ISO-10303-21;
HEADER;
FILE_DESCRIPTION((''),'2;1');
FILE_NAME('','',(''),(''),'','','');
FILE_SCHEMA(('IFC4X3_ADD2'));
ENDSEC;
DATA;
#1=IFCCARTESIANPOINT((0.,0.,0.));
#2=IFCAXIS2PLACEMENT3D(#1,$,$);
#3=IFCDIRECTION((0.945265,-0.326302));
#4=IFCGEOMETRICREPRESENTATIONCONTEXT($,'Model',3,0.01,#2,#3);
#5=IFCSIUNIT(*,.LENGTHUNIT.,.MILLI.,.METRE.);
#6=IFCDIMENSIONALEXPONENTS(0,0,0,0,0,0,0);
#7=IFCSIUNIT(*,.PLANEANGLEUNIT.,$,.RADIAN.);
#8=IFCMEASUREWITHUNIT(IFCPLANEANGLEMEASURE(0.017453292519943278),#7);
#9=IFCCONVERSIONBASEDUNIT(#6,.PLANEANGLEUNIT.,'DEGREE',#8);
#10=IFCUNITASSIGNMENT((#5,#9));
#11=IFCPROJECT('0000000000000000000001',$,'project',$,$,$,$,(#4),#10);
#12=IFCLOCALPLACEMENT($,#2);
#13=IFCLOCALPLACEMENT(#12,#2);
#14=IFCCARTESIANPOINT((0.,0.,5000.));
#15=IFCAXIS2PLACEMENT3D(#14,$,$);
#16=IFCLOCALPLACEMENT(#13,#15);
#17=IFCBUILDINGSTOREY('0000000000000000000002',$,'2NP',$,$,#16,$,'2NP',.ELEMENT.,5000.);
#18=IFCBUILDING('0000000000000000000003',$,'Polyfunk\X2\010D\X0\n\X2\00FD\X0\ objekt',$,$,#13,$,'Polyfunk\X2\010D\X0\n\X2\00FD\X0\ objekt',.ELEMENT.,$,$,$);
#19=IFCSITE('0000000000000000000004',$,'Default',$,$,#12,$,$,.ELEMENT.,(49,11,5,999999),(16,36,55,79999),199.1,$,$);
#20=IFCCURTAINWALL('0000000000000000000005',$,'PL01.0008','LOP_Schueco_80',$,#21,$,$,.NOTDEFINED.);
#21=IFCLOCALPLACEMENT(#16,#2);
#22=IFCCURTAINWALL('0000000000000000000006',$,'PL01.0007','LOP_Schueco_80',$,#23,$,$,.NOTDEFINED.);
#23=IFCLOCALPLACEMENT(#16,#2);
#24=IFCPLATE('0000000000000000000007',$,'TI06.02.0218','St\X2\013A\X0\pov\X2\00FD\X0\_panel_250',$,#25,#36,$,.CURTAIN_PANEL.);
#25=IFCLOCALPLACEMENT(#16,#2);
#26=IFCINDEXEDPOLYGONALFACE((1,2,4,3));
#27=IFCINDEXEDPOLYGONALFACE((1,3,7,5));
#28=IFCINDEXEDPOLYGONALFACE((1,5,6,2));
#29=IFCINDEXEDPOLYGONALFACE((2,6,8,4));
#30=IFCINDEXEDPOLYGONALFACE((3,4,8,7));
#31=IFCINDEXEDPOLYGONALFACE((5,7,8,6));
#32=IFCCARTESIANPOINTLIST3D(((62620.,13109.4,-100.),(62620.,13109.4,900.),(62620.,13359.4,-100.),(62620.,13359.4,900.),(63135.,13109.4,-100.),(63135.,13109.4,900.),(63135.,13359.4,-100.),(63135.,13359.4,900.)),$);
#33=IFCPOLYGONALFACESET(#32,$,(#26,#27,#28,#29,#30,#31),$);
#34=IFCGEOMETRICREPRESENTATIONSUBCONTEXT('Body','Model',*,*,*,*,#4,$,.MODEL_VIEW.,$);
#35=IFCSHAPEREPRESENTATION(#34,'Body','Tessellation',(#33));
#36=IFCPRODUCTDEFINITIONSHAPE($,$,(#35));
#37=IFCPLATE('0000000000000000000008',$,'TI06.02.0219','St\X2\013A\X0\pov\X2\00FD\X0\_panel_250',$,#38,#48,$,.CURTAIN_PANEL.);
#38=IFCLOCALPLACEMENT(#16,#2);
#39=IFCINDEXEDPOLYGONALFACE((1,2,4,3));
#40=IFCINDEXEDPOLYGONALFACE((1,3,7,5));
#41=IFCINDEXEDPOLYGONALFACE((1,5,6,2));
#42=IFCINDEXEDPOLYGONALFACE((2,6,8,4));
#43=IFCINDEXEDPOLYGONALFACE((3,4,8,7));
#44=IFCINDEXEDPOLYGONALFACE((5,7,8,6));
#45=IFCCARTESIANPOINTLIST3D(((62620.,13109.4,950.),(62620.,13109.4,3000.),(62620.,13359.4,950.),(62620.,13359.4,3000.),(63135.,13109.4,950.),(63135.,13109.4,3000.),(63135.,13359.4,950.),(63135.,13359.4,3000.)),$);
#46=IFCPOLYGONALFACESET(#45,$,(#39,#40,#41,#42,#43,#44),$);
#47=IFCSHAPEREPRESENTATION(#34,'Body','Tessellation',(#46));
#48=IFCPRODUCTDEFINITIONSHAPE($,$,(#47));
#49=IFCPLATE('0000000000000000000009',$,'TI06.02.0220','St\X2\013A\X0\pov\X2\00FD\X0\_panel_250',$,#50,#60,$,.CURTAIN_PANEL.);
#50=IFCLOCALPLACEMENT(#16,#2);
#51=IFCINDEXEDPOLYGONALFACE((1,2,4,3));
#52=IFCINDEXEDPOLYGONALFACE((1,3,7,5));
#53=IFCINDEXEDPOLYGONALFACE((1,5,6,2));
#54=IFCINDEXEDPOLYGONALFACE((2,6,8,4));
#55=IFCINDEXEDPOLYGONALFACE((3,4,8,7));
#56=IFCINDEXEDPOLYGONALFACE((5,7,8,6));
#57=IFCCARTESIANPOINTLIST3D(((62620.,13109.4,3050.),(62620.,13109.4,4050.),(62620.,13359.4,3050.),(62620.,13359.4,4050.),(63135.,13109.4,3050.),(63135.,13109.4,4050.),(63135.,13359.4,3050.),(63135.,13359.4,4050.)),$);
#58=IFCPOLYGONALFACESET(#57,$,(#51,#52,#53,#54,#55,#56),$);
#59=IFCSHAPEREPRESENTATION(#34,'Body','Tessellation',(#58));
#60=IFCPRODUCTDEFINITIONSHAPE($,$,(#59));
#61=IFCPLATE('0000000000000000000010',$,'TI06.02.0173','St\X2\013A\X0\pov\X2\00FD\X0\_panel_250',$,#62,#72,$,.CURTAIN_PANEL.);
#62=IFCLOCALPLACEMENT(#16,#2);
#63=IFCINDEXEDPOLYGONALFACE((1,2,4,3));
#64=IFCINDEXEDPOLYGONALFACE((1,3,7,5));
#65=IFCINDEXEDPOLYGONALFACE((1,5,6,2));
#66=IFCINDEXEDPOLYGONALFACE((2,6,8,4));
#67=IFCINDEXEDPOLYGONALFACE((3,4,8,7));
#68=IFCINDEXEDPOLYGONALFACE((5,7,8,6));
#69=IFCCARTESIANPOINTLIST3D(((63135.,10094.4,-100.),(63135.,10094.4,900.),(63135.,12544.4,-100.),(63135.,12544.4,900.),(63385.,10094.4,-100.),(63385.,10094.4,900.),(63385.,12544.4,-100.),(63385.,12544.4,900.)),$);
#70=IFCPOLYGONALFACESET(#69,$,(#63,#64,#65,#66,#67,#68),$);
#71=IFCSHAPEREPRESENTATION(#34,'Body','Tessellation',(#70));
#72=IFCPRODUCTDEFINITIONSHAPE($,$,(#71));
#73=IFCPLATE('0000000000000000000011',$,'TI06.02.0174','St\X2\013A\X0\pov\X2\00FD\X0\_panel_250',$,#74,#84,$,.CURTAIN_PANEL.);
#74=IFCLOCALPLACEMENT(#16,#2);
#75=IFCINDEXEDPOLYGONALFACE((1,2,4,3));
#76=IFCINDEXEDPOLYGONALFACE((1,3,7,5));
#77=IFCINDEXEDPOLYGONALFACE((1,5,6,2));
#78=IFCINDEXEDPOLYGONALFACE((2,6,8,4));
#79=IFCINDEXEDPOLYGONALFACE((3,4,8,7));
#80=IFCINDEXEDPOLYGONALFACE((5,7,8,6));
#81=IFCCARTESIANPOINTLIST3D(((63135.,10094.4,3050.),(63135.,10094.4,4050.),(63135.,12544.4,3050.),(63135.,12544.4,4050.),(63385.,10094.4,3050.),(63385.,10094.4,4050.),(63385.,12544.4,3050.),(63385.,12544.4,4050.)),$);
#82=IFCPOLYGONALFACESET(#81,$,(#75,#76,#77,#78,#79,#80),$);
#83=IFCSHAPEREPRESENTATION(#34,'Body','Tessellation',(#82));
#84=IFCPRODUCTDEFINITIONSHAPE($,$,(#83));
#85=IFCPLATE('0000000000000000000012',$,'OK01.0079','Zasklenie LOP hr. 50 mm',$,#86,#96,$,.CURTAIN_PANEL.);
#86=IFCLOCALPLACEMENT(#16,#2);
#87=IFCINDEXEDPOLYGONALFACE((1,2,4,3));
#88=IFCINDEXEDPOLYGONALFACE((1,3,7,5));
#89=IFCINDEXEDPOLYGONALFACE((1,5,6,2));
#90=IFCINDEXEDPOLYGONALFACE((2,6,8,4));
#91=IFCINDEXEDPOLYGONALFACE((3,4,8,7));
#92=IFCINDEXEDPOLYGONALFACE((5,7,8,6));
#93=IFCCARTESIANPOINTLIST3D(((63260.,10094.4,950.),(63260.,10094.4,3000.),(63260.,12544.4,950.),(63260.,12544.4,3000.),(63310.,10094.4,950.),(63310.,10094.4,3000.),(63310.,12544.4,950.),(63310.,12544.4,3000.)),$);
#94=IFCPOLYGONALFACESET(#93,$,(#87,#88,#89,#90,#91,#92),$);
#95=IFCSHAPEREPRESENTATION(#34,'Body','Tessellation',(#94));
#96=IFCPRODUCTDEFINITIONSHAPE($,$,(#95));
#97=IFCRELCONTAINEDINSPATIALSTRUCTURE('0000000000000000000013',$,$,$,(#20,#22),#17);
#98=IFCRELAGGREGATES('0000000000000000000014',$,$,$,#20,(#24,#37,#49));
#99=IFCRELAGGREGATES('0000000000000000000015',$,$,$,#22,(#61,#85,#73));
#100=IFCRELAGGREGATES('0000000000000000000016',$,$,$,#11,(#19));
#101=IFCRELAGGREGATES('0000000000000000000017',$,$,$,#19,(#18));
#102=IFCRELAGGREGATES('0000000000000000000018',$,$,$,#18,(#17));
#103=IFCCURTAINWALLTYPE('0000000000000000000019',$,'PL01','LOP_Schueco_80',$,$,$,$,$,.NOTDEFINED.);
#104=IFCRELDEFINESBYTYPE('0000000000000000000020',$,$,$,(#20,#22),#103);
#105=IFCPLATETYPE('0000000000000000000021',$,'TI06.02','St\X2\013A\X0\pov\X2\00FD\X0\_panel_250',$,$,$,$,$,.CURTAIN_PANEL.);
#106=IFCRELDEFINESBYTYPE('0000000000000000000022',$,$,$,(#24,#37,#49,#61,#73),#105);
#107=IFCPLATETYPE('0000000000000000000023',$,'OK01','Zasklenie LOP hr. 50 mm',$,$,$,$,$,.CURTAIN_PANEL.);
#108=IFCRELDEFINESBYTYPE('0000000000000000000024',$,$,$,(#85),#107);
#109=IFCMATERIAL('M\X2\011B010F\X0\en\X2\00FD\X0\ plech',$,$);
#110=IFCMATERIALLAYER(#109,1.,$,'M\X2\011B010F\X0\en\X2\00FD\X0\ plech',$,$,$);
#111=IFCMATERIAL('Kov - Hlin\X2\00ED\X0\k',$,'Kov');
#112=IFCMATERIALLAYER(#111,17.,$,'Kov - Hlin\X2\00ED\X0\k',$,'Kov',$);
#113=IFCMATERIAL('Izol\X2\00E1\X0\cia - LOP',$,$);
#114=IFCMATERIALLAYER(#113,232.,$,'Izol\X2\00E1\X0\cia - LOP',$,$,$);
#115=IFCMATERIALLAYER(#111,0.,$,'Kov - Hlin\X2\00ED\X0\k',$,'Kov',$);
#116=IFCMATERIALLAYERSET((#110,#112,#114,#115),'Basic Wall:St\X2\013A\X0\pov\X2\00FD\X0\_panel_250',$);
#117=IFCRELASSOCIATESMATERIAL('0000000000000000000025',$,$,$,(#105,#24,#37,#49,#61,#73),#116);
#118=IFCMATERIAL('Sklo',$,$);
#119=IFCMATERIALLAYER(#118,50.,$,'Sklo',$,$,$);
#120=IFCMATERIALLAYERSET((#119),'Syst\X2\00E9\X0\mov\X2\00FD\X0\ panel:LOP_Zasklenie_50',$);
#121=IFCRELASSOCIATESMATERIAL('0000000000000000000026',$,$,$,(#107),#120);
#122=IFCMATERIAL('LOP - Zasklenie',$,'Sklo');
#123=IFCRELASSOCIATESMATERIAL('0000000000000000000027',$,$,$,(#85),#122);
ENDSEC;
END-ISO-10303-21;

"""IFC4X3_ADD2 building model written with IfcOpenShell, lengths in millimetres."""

from ifc_helpers import new_model, entity, si_unit, converted_unit, direction, frame, frame_2d, origin, origin_2d_with_axis, place, context, subcontext, project, spatial, rectangle, extrude, source, transform, mapped, material, layer, layer_set, layer_usage, type_object, type_shapes, element, aggregate, save


model = new_model("IFC4X3_ADD2")

# Units and contexts
model_context = context("Model", 3, precision=0.01, world=origin(), true_north=direction((0.945265, -0.326302)))
body_context = subcontext(model_context, "Body", "Model", "MODEL_VIEW")
ifc_project = project(units=[si_unit("LENGTHUNIT", "METRE", prefix="MILLI"), converted_unit("PLANEANGLEUNIT", "DEGREE", entity("IfcPlaneAngleMeasure", 0.017453292519943278), si_unit("PLANEANGLEUNIT", "RADIAN"), dimensions=[0, 0, 0, 0, 0, 0, 0])], contexts=[model_context])

# Site, building, storey
site_placement = place(None, origin())
site = spatial("IfcSite", under=ifc_project, at=site_placement, Name="Default", CompositionType="ELEMENT", RefLatitude=(49, 11, 5, 999999), RefLongitude=(16, 36, 55, 79999), RefElevation=199.1)
building_placement = place(site_placement, origin())
building = spatial("IfcBuilding", under=site, at=building_placement, Name="Polyfunkčný objekt", LongName="Polyfunkčný objekt", CompositionType="ELEMENT")
storey_placement = place(building_placement, frame((0.0, 0.0, 5000.0)))
storey = spatial("IfcBuildingStorey", under=building, at=storey_placement, Name="2NP", LongName="2NP", CompositionType="ELEMENT", Elevation=5000.0)

# Curtain walls
curtain_wall_type = type_object("IfcCurtainWallType", Name="PL01", Description="LOP_Schueco_80", PredefinedType="NOTDEFINED")
curtain_wall_1_placement = place(storey_placement, frame((0.0, 0.0, -5000.0)))
curtain_wall_1 = element("IfcCurtainWall", 1, at=curtain_wall_1_placement, inside=storey, type_object=curtain_wall_type, Name="PL01.0008", Description="LOP_Schueco_80", PredefinedType="NOTDEFINED")
curtain_wall_2_placement = place(storey_placement, frame((0.0, 0.0, -5000.0)))
curtain_wall_2 = element("IfcCurtainWall", 2, at=curtain_wall_2_placement, inside=storey, type_object=curtain_wall_type, Name="PL01.0007", Description="LOP_Schueco_80", PredefinedType="NOTDEFINED")

# Plates
ifc_material_1 = material(Name="Měďený plech")
ifc_layer_1 = layer(ifc_material_1, 1.0, Name="Měďený plech")
ifc_material_2 = material(Name="Kov - Hliník", Category="Kov")
ifc_layer_2 = layer(ifc_material_2, 17.0, Name="Kov - Hliník", Category="Kov")
ifc_material_3 = material(Name="Izolácia - LOP")
ifc_layer_3 = layer(ifc_material_3, 232.0, Name="Izolácia - LOP")
ifc_layer_4 = layer(ifc_material_2, 0.0, Name="Kov - Hliník", Category="Kov")
ifc_layer_set_1 = layer_set([ifc_layer_1, ifc_layer_2, ifc_layer_3, ifc_layer_4], Name="Basic Wall:Stĺpový_panel_250")
ifc_layer_usage_1 = layer_usage(ifc_layer_set_1, "AXIS2", "NEGATIVE", 125.0)
plate_type_1 = type_object("IfcPlateType", Name="TI06.02", Description="Stĺpový_panel_250", PredefinedType="CURTAIN_PANEL", material=ifc_layer_set_1)
plate_1_placement = place(storey_placement, frame((62620.0, 13234.4, -100.0)))
plate_1 = element("IfcPlate", 3, at=plate_1_placement, type_object=plate_type_1, material=ifc_layer_usage_1, Name="TI06.02.0218", Description="Stĺpový_panel_250", PredefinedType="CURTAIN_PANEL", context=body_context, shape_type="SweptSolid", body=[
    extrude(rectangle(XDim=250.0, YDim=515.0, at=frame_2d((0.0, 0.0), x_axis=(1.0, 0.0))), frame((257.5, 0.0, 0.0), z_axis=(0.0, 0.0, 1.0), x_axis=(0.0, 1.0, 0.0)), (0.0, 0.0, 1.0), 1000.0),
])
ifc_layer_usage_2 = layer_usage(ifc_layer_set_1, "AXIS2", "NEGATIVE", 125.0)
plate_2_placement = place(storey_placement, frame((62620.0, 13234.4, 950.0)))
plate_2 = element("IfcPlate", 4, at=plate_2_placement, type_object=plate_type_1, material=ifc_layer_usage_2, Name="TI06.02.0219", Description="Stĺpový_panel_250", PredefinedType="CURTAIN_PANEL", context=body_context, shape_type="SweptSolid", body=[
    extrude(rectangle(XDim=250.0, YDim=515.0, at=frame_2d((0.0, 0.0), x_axis=(1.0, 0.0))), frame((257.5, 0.0, 0.0), z_axis=(0.0, 0.0, 1.0), x_axis=(0.0, 1.0, 0.0)), (0.0, 0.0, 1.0), 2050.0),
])
ifc_layer_usage_3 = layer_usage(ifc_layer_set_1, "AXIS2", "NEGATIVE", 125.0)
plate_3_placement = place(storey_placement, frame((62620.0, 13234.4, 3050.0)))
plate_3 = element("IfcPlate", 5, at=plate_3_placement, type_object=plate_type_1, material=ifc_layer_usage_3, Name="TI06.02.0220", Description="Stĺpový_panel_250", PredefinedType="CURTAIN_PANEL", context=body_context, shape_type="SweptSolid", body=[
    extrude(rectangle(XDim=250.0, YDim=515.0, at=frame_2d((0.0, 0.0), x_axis=(1.0, 0.0))), frame((257.5, 0.0, 0.0), z_axis=(0.0, 0.0, 1.0), x_axis=(0.0, 1.0, 0.0)), (0.0, 0.0, 1.0), 1000.0),
])
aggregate(curtain_wall_1, [plate_1, plate_2, plate_3])
ifc_layer_usage_4 = layer_usage(ifc_layer_set_1, "AXIS2", "NEGATIVE", 125.0)
plate_4_placement = place(storey_placement, frame((63260.0, 12544.4, -100.0), z_axis=(0.0, 0.0, 1.0), x_axis=(0.0, -1.0, 0.0)))
plate_4 = element("IfcPlate", 6, at=plate_4_placement, type_object=plate_type_1, material=ifc_layer_usage_4, Name="TI06.02.0173", Description="Stĺpový_panel_250", PredefinedType="CURTAIN_PANEL", context=body_context, shape_type="SweptSolid", body=[
    extrude(rectangle(XDim=250.0, YDim=2450.0, at=frame_2d((0.0, 0.0), x_axis=(1.0, 0.0))), frame((1225.0, 0.0, 0.0), z_axis=(0.0, 0.0, 1.0), x_axis=(0.0, 1.0, 0.0)), (0.0, 0.0, 1.0), 1000.0),
])
ifc_layer_usage_5 = layer_usage(ifc_layer_set_1, "AXIS2", "NEGATIVE", 125.0)
plate_5_placement = place(storey_placement, frame((63260.0, 12544.4, 3050.0), z_axis=(0.0, 0.0, 1.0), x_axis=(0.0, -1.0, 0.0)))
plate_5 = element("IfcPlate", 7, at=plate_5_placement, type_object=plate_type_1, material=ifc_layer_usage_5, Name="TI06.02.0174", Description="Stĺpový_panel_250", PredefinedType="CURTAIN_PANEL", context=body_context, shape_type="SweptSolid", body=[
    extrude(rectangle(XDim=250.0, YDim=2450.0, at=frame_2d((0.0, 0.0), x_axis=(1.0, 0.0))), frame((1225.0, 0.0, 0.0), z_axis=(0.0, 0.0, 1.0), x_axis=(0.0, 1.0, 0.0)), (0.0, 0.0, 1.0), 1000.0),
])
ifc_material_4 = material(Name="LOP - Zasklenie", Category="Sklo")
ifc_material_5 = material(Name="Sklo")
ifc_layer_5 = layer(ifc_material_5, 50.0, Name="Sklo")
ifc_layer_set_2 = layer_set([ifc_layer_5], Name="Systémový panel:LOP_Zasklenie_50")
plate_type_2 = type_object("IfcPlateType", Name="OK01", Description="Zasklenie LOP hr. 50 mm", PredefinedType="CURTAIN_PANEL", material=ifc_layer_set_2)
shared_shape_1 = source(origin(), body_context, "Body", "SweptSolid", [
    extrude(rectangle(XDim=50.0, YDim=2450.0, at=origin_2d_with_axis()), frame((0.0, 25.0, 0.0), z_axis=(0.0, 0.0, 1.0), x_axis=(0.0, 1.0, 0.0)), (0.0, 0.0, 1.0), 2050.0),
])
type_shapes(plate_type_2, [shared_shape_1])
plate_6_placement = place(curtain_wall_2_placement, frame((63260.0, 11319.4, 5950.0), z_axis=(0.0, 0.0, 1.0), x_axis=(0.0, -1.0, 0.0)))
plate_6 = element("IfcPlate", 8, at=plate_6_placement, type_object=plate_type_2, material=ifc_material_4, Name="OK01.0079", Description="Zasklenie LOP hr. 50 mm", PredefinedType="CURTAIN_PANEL", context=body_context, shape_type="MappedRepresentation", body=[
    mapped(shared_shape_1, transform((0.0, 0.0, 0.0), scale=1.0)),
])
aggregate(curtain_wall_2, [plate_4, plate_6, plate_5])

save(model, "model.ifc")
